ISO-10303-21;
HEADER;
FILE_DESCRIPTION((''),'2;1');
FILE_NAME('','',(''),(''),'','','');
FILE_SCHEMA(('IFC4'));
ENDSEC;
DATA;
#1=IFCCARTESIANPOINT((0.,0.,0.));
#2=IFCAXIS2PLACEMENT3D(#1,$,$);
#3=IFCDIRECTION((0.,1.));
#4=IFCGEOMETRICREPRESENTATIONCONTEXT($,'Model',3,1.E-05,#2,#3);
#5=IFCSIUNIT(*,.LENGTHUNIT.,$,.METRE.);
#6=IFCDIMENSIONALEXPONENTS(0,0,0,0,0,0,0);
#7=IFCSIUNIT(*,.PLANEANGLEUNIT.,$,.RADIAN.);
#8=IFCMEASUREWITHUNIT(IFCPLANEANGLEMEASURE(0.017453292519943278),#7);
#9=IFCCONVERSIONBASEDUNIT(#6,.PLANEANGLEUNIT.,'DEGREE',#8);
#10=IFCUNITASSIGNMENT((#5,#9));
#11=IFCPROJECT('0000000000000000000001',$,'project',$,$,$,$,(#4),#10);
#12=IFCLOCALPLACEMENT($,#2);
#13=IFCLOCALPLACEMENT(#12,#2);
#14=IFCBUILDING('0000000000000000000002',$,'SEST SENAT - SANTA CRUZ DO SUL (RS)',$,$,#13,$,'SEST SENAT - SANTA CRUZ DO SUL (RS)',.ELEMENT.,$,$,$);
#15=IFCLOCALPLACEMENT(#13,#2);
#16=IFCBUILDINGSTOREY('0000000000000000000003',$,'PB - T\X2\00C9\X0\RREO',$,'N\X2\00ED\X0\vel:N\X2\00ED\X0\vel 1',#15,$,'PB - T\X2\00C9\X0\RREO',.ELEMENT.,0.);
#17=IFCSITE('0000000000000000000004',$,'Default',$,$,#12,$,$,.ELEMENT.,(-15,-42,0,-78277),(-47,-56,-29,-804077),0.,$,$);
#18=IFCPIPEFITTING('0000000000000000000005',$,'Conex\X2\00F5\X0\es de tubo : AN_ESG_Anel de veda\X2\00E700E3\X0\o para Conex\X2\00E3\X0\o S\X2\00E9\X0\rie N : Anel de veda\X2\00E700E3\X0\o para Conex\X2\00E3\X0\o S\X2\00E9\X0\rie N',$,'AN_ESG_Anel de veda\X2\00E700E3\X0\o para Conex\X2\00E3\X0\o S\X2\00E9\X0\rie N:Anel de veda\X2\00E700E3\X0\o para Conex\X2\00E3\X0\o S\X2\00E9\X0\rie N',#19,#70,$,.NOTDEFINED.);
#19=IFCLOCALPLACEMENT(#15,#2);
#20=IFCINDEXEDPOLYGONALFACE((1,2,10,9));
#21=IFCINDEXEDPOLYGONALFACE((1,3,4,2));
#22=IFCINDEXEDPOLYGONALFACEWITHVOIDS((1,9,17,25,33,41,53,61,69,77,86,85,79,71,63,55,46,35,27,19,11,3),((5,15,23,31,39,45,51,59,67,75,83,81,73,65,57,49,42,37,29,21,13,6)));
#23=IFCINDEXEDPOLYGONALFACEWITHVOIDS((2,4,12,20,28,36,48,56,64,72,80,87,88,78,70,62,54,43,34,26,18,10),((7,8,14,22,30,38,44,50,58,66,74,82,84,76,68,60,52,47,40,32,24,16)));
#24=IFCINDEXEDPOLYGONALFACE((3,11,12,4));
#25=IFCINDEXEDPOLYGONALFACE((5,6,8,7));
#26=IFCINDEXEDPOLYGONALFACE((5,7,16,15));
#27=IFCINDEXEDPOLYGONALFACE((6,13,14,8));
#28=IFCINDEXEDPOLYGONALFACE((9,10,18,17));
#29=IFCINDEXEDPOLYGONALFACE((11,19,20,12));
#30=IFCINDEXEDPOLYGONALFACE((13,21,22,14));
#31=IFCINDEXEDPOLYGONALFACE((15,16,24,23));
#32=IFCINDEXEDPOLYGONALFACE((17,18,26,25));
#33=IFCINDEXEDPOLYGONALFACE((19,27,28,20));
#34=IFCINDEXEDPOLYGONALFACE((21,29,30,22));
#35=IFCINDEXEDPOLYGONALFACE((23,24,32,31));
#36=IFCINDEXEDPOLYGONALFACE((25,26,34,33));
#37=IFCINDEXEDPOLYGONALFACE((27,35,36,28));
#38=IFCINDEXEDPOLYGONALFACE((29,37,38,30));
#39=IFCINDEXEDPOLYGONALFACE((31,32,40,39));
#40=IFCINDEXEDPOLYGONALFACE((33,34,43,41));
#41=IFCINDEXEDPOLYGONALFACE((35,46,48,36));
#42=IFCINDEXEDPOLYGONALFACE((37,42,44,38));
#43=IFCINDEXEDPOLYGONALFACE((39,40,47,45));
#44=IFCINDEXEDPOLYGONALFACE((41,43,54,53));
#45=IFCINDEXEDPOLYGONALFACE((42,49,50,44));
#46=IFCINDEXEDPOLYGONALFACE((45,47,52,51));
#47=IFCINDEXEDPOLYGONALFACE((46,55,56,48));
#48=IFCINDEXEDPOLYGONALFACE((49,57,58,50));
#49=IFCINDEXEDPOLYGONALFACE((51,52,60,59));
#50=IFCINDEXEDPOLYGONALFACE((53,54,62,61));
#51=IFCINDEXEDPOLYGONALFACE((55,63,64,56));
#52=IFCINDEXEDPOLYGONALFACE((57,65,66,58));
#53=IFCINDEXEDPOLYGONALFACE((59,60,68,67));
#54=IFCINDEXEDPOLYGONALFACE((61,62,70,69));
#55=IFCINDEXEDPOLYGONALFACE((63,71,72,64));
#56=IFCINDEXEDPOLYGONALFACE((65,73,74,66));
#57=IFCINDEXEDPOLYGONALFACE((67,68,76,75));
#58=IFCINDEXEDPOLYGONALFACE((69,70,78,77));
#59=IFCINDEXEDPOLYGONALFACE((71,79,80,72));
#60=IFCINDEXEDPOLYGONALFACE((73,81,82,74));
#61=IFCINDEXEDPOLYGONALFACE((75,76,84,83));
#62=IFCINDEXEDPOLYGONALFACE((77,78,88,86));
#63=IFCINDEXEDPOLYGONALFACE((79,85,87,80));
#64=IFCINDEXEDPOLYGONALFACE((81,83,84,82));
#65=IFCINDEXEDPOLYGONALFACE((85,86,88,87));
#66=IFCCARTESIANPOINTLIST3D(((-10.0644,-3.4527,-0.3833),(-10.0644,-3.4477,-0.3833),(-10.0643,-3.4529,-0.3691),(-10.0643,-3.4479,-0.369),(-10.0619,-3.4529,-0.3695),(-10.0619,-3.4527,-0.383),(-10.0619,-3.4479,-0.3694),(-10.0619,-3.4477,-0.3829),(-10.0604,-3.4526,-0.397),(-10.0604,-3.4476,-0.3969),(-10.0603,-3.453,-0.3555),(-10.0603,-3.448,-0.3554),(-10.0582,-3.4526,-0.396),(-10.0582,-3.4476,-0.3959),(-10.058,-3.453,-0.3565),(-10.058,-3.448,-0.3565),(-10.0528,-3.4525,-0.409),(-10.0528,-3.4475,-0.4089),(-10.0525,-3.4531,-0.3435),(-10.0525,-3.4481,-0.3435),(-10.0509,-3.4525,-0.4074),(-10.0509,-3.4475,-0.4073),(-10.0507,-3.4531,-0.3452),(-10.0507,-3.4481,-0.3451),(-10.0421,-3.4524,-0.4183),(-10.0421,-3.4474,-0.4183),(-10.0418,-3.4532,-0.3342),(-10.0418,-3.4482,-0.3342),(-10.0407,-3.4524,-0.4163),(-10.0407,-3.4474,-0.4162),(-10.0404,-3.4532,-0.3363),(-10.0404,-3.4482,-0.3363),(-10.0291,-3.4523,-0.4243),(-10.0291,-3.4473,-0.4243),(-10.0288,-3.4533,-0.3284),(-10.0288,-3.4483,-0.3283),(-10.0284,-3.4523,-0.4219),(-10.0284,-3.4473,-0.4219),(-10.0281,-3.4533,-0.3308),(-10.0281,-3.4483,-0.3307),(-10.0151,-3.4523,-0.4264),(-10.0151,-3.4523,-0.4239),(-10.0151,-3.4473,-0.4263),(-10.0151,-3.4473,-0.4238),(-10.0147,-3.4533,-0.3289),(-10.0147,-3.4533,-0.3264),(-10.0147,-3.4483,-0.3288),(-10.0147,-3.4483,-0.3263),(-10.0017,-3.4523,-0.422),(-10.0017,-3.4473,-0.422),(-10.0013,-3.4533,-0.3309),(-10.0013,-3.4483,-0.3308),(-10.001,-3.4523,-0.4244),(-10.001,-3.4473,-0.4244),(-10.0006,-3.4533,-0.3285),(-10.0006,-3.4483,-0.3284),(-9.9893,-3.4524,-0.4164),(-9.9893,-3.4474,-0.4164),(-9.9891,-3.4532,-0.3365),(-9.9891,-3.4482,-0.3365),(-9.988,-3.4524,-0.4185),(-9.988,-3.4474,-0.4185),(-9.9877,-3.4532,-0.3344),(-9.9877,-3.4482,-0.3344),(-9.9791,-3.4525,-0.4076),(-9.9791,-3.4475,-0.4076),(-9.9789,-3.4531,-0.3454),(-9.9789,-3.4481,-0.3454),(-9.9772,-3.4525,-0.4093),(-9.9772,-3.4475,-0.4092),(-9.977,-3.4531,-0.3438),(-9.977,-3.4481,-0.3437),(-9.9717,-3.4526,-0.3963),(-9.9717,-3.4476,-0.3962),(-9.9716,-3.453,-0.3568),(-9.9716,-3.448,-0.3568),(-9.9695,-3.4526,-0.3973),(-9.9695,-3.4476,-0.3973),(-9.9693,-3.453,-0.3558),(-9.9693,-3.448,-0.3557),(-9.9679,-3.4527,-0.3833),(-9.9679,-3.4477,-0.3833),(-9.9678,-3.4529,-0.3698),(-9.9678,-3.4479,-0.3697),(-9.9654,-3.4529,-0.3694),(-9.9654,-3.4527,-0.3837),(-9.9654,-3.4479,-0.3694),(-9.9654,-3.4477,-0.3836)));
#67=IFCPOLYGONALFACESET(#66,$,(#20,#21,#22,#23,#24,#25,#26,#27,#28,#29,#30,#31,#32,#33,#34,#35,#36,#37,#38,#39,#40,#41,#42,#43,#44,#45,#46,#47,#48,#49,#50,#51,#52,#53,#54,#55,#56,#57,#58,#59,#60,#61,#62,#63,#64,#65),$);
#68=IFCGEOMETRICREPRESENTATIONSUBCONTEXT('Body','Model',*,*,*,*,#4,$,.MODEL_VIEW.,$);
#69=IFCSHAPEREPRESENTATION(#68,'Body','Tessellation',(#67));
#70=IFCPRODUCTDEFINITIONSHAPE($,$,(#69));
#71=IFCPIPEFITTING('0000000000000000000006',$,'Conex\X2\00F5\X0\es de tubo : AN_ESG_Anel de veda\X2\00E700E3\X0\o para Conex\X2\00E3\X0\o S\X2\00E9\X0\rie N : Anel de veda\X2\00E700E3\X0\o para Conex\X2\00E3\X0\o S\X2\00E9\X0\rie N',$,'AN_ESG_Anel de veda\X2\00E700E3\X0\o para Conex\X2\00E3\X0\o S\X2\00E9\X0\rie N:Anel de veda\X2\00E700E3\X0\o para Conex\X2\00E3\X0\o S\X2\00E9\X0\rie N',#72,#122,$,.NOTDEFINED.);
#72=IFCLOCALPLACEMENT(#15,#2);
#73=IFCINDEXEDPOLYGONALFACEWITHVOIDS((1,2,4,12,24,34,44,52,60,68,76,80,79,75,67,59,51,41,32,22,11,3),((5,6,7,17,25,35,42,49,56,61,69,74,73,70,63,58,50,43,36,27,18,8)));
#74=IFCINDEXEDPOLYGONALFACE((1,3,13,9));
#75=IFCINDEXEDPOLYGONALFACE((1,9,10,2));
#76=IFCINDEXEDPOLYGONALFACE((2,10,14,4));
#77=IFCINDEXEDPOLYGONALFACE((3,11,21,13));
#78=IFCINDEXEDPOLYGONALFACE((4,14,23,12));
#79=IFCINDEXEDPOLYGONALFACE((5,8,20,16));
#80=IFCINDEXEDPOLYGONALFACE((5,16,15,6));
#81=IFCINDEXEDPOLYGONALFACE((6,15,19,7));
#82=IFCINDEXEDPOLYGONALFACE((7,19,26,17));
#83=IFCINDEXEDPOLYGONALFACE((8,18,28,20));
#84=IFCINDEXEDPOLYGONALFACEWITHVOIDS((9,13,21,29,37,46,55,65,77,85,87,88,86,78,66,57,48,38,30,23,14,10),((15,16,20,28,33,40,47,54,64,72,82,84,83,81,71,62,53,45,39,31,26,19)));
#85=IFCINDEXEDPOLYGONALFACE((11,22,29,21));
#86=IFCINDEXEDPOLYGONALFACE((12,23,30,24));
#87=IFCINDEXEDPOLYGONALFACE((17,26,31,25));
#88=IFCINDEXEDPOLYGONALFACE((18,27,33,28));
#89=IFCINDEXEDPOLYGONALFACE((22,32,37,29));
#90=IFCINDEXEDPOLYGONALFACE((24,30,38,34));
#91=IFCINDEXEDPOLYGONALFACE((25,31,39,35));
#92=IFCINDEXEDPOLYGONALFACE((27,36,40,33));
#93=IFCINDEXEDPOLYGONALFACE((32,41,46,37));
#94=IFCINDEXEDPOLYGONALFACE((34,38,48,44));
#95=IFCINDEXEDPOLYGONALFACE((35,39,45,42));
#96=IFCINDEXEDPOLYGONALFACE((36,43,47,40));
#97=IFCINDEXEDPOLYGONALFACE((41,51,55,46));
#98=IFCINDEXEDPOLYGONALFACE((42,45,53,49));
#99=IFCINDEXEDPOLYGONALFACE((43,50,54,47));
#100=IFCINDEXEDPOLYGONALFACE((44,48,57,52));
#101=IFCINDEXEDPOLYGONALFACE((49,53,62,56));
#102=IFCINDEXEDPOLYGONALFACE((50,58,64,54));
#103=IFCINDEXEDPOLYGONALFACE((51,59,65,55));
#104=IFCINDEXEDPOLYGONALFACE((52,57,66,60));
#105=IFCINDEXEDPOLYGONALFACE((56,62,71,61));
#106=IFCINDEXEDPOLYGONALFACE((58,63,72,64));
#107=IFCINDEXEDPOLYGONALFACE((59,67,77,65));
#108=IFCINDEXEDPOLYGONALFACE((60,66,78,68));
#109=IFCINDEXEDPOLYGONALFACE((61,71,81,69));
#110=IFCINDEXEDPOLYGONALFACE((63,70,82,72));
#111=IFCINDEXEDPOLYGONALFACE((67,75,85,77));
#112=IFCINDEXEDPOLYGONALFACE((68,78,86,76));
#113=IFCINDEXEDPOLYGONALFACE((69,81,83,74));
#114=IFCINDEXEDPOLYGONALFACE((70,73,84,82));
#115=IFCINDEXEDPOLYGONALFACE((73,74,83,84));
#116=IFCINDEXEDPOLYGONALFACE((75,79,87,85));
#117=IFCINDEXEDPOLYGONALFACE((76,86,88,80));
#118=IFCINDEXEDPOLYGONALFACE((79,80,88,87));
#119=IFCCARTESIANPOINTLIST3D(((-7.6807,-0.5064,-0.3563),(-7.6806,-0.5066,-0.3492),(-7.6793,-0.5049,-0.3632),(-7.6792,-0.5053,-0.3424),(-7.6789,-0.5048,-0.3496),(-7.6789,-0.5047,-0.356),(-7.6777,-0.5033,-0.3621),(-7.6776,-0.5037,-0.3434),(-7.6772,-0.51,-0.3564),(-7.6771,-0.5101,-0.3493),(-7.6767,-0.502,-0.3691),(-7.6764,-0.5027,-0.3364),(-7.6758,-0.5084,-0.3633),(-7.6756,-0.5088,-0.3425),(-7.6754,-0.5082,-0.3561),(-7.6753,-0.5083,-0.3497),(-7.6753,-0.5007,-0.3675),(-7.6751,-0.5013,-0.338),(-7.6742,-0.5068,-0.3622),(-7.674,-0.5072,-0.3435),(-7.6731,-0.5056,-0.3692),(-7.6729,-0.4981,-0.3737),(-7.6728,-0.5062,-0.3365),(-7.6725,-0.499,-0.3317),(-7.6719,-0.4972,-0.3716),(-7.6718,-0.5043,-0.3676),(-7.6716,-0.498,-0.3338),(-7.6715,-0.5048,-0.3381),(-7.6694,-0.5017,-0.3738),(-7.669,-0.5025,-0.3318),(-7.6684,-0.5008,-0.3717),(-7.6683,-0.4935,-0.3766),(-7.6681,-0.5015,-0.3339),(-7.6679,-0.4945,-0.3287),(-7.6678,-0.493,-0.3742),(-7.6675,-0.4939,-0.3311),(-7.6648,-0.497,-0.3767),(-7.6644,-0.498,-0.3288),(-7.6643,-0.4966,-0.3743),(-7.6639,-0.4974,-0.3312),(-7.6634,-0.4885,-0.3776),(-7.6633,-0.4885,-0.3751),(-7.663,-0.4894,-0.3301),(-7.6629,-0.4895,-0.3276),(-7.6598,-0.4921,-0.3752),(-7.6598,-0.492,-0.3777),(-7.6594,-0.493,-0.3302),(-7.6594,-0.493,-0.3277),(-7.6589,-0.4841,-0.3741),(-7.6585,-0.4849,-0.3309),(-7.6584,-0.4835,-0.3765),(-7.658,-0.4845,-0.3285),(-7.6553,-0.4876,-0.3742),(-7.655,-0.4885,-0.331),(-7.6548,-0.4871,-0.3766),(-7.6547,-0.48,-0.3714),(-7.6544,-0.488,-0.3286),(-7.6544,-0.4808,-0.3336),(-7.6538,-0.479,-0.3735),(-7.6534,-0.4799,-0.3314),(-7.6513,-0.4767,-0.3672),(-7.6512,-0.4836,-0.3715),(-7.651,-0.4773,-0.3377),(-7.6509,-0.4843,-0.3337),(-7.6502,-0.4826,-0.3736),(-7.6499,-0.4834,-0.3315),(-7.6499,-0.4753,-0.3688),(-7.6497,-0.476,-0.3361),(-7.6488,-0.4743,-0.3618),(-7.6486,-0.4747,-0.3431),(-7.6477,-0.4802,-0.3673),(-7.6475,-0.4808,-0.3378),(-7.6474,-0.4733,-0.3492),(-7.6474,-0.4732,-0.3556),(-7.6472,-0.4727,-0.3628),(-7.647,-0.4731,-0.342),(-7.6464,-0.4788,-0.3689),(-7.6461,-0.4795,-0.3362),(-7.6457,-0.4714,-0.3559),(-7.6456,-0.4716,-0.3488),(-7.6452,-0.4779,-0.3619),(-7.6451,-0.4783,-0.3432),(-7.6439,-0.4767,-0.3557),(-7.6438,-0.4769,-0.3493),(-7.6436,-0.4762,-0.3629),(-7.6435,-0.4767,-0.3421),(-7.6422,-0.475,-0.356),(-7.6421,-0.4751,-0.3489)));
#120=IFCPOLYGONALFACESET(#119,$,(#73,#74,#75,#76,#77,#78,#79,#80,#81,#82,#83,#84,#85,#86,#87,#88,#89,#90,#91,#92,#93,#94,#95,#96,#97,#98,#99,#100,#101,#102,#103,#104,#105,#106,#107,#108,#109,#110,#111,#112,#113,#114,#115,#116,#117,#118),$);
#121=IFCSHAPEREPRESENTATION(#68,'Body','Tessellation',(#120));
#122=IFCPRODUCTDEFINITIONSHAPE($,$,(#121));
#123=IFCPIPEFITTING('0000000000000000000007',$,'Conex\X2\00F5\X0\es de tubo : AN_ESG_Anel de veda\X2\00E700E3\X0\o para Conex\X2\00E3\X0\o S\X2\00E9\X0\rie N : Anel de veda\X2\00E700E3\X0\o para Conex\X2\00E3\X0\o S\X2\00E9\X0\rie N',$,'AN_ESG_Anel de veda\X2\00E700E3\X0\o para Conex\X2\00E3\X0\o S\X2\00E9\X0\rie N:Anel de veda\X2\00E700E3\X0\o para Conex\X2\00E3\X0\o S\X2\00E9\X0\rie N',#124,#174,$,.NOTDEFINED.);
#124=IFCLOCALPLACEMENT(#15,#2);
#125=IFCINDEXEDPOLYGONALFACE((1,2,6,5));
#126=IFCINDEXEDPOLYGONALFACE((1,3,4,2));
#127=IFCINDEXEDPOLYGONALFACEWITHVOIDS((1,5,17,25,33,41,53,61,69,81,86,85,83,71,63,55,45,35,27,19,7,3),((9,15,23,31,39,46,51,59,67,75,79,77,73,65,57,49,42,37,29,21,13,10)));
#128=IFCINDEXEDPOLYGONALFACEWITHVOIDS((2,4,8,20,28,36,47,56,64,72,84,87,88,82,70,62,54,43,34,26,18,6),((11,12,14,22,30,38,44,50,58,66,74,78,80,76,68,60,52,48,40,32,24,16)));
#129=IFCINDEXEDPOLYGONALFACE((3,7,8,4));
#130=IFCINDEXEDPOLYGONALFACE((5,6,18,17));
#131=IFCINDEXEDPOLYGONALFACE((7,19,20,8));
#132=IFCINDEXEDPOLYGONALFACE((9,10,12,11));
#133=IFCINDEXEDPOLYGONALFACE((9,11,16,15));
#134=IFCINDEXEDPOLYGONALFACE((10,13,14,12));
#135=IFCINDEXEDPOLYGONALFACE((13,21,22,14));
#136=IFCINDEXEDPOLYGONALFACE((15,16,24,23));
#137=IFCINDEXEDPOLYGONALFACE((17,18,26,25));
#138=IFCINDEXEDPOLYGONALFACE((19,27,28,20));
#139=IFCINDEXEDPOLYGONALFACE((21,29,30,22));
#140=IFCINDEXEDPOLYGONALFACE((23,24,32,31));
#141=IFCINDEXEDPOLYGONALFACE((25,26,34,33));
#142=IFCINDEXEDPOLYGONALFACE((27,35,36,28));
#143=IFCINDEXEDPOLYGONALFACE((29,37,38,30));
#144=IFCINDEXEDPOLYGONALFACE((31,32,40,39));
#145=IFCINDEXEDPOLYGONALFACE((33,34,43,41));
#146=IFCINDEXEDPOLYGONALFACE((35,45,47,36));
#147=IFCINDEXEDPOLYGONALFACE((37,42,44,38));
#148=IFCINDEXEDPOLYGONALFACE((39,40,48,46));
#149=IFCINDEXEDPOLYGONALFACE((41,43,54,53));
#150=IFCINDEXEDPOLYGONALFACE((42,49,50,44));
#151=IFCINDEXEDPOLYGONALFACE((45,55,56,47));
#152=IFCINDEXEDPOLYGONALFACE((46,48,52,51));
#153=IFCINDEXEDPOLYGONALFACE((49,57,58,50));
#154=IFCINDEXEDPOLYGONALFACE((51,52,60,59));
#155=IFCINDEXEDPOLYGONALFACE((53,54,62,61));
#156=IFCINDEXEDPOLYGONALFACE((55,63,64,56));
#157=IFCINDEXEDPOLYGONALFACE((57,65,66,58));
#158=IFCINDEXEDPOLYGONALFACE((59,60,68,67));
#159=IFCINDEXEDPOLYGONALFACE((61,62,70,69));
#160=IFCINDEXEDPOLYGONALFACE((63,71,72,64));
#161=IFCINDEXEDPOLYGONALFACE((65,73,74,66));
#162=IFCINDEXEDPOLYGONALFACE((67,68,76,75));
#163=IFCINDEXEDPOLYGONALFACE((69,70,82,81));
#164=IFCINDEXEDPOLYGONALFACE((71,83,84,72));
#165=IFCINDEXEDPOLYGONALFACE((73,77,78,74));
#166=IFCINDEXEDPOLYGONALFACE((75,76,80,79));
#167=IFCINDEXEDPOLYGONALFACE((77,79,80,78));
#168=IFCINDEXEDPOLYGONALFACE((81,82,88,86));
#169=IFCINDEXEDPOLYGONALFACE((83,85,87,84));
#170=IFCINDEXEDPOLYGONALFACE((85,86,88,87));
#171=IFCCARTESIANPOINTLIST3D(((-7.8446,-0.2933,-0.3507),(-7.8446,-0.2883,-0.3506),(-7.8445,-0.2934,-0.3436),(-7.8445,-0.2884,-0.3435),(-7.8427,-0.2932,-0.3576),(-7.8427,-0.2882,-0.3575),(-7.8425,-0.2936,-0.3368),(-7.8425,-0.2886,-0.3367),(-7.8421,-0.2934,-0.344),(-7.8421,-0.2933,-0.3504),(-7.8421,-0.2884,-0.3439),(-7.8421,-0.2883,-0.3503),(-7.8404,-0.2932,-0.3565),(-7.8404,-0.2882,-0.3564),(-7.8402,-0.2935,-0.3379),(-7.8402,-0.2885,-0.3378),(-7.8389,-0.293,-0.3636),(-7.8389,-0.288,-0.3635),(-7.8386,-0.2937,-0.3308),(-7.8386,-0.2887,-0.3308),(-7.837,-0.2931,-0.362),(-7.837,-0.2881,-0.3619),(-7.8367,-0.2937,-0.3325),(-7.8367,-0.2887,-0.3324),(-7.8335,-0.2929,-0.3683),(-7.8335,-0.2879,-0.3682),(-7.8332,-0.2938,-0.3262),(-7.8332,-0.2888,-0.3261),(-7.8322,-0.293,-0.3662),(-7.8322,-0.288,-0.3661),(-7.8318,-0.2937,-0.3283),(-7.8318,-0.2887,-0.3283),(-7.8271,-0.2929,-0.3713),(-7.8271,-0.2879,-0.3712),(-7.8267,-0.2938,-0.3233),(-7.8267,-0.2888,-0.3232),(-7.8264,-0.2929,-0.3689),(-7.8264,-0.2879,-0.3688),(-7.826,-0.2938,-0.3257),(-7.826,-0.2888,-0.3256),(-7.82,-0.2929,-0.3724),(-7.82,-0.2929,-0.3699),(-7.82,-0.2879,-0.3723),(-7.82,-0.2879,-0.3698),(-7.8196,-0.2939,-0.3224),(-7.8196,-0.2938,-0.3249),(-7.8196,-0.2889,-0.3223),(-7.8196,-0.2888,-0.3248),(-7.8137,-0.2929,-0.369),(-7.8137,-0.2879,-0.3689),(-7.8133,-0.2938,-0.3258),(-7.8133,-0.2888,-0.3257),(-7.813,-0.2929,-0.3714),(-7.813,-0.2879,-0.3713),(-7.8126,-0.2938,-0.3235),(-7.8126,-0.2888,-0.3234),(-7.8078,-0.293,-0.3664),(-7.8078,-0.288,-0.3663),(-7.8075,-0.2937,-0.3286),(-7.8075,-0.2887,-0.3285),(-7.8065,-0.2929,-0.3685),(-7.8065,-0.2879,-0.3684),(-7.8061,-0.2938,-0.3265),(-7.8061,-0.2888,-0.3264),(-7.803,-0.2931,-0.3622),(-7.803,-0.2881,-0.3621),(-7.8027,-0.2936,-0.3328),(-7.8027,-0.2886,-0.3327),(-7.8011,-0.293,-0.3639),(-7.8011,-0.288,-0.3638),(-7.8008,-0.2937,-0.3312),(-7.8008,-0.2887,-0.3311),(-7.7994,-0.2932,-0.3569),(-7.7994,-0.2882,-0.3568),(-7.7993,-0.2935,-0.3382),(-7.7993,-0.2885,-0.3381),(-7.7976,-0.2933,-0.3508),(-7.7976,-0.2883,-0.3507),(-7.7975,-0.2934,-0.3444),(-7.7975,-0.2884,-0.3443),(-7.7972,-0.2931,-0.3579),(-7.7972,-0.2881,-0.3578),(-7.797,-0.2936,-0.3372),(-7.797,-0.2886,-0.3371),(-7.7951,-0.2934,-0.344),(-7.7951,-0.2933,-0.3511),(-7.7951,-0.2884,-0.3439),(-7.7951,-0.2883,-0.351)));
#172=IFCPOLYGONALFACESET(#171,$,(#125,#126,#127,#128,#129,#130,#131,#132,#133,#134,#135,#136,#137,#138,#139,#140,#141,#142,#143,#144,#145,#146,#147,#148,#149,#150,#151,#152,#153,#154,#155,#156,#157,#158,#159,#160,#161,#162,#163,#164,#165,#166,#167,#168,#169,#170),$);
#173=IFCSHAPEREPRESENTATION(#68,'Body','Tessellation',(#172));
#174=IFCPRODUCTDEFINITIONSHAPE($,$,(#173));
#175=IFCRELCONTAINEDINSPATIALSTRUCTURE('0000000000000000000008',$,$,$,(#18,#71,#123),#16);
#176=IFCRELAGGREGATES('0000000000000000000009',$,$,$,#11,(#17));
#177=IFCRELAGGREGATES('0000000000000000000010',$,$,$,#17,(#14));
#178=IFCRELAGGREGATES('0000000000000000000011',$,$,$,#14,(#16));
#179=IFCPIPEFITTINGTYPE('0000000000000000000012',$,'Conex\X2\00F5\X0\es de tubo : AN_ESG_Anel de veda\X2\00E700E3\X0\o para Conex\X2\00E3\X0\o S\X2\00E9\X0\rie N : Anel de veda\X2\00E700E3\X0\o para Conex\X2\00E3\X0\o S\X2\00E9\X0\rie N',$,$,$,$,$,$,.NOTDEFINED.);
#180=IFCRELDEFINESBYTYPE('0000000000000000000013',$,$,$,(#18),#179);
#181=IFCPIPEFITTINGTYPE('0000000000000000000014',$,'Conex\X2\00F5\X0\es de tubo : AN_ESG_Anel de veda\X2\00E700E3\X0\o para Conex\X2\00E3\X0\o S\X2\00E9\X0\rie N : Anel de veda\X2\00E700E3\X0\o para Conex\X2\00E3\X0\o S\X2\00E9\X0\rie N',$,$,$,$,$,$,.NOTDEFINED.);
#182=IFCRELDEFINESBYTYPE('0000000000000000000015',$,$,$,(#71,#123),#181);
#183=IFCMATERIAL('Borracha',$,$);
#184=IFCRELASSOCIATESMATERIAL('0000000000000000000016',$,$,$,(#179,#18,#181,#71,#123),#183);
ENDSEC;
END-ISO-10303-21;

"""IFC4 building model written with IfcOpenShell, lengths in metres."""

from ifc_helpers import new_model, entity, si_unit, converted_unit, direction, frame, origin, place, context, subcontext, project, spatial, arc, indexed_curve, outline, extrude, source, transform, mapped, material, type_object, type_shapes, element, save


model = new_model("IFC4")

# Units and contexts
model_context = context("Model", 3, precision=1e-05, world=origin(), true_north=direction((0.0, 1.0)))
body_context = subcontext(model_context, "Body", "Model", "MODEL_VIEW")
ifc_project = project(units=[si_unit("LENGTHUNIT", "METRE"), converted_unit("PLANEANGLEUNIT", "DEGREE", entity("IfcPlaneAngleMeasure", 0.017453292519943278), si_unit("PLANEANGLEUNIT", "RADIAN"), dimensions=[0, 0, 0, 0, 0, 0, 0])], contexts=[model_context])

# Site, building, storey
site_placement = place(None, origin())
site = spatial("IfcSite", under=ifc_project, at=site_placement, Name="Default", CompositionType="ELEMENT", RefLatitude=(-15, -42, 0, -78277), RefLongitude=(-47, -56, -29, -804077), RefElevation=0.0)
building_placement = place(site_placement, origin())
building = spatial("IfcBuilding", under=site, at=building_placement, Name="SEST SENAT - SANTA CRUZ DO SUL (RS)", LongName="SEST SENAT - SANTA CRUZ DO SUL (RS)", CompositionType="ELEMENT")
storey_placement = place(building_placement, origin())
storey = spatial("IfcBuildingStorey", under=building, at=storey_placement, Name="PB - TÉRREO", ObjectType="Nível:Nível 1", LongName="PB - TÉRREO", CompositionType="ELEMENT", Elevation=0.0)

# Pipe fittings
ifc_material_1 = material(Name="Borracha")
pipe_fitting_type_1 = type_object("IfcPipeFittingType", Name="Conexões de tubo : AN_ESG_Anel de vedação para Conexão Série N : Anel de vedação para Conexão Série N", PredefinedType="NOTDEFINED", material=ifc_material_1)
shared_shape_1 = source(origin(), body_context, "Body", "SweptSolid", [
    extrude(outline(indexed_curve([(-0.05, 0.0), (0.0, -0.05), (0.05, 0.0), (0.0, 0.05)], segments=[arc(1, 2, 3), arc(3, 4, 1)], self_intersect=False), holes=[indexed_curve([(-0.0475, 0.0), (0.0, 0.0475), (0.0475, 0.0), (0.0, -0.0475)], segments=[arc(1, 2, 3), arc(3, 4, 1)], self_intersect=False)]), frame((0.0, 0.0, -0.005)), (0.0, 0.0, 1.0), 0.005),
])
type_shapes(pipe_fitting_type_1, [shared_shape_1])
pipe_fitting_placement = place(storey_placement, frame((-10.0149, -3.4528, -0.3764), z_axis=(0.0, -0.99995, -0.01), x_axis=(0.003595, -0.009999, 0.999944)))
element("IfcPipeFitting", 1, at=pipe_fitting_placement, inside=storey, type_object=pipe_fitting_type_1, material=ifc_material_1, Name="Conexões de tubo : AN_ESG_Anel de vedação para Conexão Série N : Anel de vedação para Conexão Série N", ObjectType="AN_ESG_Anel de vedação para Conexão Série N:Anel de vedação para Conexão Série N", PredefinedType="NOTDEFINED", context=body_context, shape_type="MappedRepresentation", body=[
    mapped(shared_shape_1, transform((0.0, 0.0, 0.0), scale=1.0)),
])
pipe_fitting_type_2 = type_object("IfcPipeFittingType", Name="Conexões de tubo : AN_ESG_Anel de vedação para Conexão Série N : Anel de vedação para Conexão Série N", PredefinedType="NOTDEFINED", material=ifc_material_1)
shared_shape_2 = source(origin(), body_context, "Body", "SweptSolid", [
    extrude(outline(indexed_curve([(-0.025, 0.0), (0.0, -0.025), (0.025, 0.0), (0.0, 0.025)], segments=[arc(1, 2, 3), arc(3, 4, 1)], self_intersect=False), holes=[indexed_curve([(-0.0225, 0.0), (0.0, 0.0225), (0.0225, 0.0), (0.0, -0.0225)], segments=[arc(1, 2, 3), arc(3, 4, 1)], self_intersect=False)]), frame((0.0, 0.0, -0.005)), (0.0, 0.0, 1.0), 0.005),
])
type_shapes(pipe_fitting_type_2, [shared_shape_2])
for number, where, z_axis, x_axis, name in (
    (2, (-7.6596, -0.4925, -0.3527), (0.706948, -0.706983, -0.019996), (-0.008302, 0.019975, -0.999766), "Conexões de tubo : AN_ESG_Anel de vedação para Conexão Série N : Anel de vedação para Conexão Série N"),
    (3, (-7.8198, -0.2884, -0.3473), (0.0, 0.999801, 0.019946), (0.008332, -0.019945, 0.999766), "Conexões de tubo : AN_ESG_Anel de vedação para Conexão Série N : Anel de vedação para Conexão Série N"),
):
    element("IfcPipeFitting", number, at=place(storey_placement, frame(where, z_axis=z_axis, x_axis=x_axis)), inside=storey, type_object=pipe_fitting_type_2, material=ifc_material_1, Name=name, ObjectType="AN_ESG_Anel de vedação para Conexão Série N:Anel de vedação para Conexão Série N", PredefinedType="NOTDEFINED", context=body_context, shape_type="MappedRepresentation", body=[
        mapped(shared_shape_2, transform((0.0, 0.0, 0.0), scale=1.0)),
    ])

save(model, "model.ifc")
